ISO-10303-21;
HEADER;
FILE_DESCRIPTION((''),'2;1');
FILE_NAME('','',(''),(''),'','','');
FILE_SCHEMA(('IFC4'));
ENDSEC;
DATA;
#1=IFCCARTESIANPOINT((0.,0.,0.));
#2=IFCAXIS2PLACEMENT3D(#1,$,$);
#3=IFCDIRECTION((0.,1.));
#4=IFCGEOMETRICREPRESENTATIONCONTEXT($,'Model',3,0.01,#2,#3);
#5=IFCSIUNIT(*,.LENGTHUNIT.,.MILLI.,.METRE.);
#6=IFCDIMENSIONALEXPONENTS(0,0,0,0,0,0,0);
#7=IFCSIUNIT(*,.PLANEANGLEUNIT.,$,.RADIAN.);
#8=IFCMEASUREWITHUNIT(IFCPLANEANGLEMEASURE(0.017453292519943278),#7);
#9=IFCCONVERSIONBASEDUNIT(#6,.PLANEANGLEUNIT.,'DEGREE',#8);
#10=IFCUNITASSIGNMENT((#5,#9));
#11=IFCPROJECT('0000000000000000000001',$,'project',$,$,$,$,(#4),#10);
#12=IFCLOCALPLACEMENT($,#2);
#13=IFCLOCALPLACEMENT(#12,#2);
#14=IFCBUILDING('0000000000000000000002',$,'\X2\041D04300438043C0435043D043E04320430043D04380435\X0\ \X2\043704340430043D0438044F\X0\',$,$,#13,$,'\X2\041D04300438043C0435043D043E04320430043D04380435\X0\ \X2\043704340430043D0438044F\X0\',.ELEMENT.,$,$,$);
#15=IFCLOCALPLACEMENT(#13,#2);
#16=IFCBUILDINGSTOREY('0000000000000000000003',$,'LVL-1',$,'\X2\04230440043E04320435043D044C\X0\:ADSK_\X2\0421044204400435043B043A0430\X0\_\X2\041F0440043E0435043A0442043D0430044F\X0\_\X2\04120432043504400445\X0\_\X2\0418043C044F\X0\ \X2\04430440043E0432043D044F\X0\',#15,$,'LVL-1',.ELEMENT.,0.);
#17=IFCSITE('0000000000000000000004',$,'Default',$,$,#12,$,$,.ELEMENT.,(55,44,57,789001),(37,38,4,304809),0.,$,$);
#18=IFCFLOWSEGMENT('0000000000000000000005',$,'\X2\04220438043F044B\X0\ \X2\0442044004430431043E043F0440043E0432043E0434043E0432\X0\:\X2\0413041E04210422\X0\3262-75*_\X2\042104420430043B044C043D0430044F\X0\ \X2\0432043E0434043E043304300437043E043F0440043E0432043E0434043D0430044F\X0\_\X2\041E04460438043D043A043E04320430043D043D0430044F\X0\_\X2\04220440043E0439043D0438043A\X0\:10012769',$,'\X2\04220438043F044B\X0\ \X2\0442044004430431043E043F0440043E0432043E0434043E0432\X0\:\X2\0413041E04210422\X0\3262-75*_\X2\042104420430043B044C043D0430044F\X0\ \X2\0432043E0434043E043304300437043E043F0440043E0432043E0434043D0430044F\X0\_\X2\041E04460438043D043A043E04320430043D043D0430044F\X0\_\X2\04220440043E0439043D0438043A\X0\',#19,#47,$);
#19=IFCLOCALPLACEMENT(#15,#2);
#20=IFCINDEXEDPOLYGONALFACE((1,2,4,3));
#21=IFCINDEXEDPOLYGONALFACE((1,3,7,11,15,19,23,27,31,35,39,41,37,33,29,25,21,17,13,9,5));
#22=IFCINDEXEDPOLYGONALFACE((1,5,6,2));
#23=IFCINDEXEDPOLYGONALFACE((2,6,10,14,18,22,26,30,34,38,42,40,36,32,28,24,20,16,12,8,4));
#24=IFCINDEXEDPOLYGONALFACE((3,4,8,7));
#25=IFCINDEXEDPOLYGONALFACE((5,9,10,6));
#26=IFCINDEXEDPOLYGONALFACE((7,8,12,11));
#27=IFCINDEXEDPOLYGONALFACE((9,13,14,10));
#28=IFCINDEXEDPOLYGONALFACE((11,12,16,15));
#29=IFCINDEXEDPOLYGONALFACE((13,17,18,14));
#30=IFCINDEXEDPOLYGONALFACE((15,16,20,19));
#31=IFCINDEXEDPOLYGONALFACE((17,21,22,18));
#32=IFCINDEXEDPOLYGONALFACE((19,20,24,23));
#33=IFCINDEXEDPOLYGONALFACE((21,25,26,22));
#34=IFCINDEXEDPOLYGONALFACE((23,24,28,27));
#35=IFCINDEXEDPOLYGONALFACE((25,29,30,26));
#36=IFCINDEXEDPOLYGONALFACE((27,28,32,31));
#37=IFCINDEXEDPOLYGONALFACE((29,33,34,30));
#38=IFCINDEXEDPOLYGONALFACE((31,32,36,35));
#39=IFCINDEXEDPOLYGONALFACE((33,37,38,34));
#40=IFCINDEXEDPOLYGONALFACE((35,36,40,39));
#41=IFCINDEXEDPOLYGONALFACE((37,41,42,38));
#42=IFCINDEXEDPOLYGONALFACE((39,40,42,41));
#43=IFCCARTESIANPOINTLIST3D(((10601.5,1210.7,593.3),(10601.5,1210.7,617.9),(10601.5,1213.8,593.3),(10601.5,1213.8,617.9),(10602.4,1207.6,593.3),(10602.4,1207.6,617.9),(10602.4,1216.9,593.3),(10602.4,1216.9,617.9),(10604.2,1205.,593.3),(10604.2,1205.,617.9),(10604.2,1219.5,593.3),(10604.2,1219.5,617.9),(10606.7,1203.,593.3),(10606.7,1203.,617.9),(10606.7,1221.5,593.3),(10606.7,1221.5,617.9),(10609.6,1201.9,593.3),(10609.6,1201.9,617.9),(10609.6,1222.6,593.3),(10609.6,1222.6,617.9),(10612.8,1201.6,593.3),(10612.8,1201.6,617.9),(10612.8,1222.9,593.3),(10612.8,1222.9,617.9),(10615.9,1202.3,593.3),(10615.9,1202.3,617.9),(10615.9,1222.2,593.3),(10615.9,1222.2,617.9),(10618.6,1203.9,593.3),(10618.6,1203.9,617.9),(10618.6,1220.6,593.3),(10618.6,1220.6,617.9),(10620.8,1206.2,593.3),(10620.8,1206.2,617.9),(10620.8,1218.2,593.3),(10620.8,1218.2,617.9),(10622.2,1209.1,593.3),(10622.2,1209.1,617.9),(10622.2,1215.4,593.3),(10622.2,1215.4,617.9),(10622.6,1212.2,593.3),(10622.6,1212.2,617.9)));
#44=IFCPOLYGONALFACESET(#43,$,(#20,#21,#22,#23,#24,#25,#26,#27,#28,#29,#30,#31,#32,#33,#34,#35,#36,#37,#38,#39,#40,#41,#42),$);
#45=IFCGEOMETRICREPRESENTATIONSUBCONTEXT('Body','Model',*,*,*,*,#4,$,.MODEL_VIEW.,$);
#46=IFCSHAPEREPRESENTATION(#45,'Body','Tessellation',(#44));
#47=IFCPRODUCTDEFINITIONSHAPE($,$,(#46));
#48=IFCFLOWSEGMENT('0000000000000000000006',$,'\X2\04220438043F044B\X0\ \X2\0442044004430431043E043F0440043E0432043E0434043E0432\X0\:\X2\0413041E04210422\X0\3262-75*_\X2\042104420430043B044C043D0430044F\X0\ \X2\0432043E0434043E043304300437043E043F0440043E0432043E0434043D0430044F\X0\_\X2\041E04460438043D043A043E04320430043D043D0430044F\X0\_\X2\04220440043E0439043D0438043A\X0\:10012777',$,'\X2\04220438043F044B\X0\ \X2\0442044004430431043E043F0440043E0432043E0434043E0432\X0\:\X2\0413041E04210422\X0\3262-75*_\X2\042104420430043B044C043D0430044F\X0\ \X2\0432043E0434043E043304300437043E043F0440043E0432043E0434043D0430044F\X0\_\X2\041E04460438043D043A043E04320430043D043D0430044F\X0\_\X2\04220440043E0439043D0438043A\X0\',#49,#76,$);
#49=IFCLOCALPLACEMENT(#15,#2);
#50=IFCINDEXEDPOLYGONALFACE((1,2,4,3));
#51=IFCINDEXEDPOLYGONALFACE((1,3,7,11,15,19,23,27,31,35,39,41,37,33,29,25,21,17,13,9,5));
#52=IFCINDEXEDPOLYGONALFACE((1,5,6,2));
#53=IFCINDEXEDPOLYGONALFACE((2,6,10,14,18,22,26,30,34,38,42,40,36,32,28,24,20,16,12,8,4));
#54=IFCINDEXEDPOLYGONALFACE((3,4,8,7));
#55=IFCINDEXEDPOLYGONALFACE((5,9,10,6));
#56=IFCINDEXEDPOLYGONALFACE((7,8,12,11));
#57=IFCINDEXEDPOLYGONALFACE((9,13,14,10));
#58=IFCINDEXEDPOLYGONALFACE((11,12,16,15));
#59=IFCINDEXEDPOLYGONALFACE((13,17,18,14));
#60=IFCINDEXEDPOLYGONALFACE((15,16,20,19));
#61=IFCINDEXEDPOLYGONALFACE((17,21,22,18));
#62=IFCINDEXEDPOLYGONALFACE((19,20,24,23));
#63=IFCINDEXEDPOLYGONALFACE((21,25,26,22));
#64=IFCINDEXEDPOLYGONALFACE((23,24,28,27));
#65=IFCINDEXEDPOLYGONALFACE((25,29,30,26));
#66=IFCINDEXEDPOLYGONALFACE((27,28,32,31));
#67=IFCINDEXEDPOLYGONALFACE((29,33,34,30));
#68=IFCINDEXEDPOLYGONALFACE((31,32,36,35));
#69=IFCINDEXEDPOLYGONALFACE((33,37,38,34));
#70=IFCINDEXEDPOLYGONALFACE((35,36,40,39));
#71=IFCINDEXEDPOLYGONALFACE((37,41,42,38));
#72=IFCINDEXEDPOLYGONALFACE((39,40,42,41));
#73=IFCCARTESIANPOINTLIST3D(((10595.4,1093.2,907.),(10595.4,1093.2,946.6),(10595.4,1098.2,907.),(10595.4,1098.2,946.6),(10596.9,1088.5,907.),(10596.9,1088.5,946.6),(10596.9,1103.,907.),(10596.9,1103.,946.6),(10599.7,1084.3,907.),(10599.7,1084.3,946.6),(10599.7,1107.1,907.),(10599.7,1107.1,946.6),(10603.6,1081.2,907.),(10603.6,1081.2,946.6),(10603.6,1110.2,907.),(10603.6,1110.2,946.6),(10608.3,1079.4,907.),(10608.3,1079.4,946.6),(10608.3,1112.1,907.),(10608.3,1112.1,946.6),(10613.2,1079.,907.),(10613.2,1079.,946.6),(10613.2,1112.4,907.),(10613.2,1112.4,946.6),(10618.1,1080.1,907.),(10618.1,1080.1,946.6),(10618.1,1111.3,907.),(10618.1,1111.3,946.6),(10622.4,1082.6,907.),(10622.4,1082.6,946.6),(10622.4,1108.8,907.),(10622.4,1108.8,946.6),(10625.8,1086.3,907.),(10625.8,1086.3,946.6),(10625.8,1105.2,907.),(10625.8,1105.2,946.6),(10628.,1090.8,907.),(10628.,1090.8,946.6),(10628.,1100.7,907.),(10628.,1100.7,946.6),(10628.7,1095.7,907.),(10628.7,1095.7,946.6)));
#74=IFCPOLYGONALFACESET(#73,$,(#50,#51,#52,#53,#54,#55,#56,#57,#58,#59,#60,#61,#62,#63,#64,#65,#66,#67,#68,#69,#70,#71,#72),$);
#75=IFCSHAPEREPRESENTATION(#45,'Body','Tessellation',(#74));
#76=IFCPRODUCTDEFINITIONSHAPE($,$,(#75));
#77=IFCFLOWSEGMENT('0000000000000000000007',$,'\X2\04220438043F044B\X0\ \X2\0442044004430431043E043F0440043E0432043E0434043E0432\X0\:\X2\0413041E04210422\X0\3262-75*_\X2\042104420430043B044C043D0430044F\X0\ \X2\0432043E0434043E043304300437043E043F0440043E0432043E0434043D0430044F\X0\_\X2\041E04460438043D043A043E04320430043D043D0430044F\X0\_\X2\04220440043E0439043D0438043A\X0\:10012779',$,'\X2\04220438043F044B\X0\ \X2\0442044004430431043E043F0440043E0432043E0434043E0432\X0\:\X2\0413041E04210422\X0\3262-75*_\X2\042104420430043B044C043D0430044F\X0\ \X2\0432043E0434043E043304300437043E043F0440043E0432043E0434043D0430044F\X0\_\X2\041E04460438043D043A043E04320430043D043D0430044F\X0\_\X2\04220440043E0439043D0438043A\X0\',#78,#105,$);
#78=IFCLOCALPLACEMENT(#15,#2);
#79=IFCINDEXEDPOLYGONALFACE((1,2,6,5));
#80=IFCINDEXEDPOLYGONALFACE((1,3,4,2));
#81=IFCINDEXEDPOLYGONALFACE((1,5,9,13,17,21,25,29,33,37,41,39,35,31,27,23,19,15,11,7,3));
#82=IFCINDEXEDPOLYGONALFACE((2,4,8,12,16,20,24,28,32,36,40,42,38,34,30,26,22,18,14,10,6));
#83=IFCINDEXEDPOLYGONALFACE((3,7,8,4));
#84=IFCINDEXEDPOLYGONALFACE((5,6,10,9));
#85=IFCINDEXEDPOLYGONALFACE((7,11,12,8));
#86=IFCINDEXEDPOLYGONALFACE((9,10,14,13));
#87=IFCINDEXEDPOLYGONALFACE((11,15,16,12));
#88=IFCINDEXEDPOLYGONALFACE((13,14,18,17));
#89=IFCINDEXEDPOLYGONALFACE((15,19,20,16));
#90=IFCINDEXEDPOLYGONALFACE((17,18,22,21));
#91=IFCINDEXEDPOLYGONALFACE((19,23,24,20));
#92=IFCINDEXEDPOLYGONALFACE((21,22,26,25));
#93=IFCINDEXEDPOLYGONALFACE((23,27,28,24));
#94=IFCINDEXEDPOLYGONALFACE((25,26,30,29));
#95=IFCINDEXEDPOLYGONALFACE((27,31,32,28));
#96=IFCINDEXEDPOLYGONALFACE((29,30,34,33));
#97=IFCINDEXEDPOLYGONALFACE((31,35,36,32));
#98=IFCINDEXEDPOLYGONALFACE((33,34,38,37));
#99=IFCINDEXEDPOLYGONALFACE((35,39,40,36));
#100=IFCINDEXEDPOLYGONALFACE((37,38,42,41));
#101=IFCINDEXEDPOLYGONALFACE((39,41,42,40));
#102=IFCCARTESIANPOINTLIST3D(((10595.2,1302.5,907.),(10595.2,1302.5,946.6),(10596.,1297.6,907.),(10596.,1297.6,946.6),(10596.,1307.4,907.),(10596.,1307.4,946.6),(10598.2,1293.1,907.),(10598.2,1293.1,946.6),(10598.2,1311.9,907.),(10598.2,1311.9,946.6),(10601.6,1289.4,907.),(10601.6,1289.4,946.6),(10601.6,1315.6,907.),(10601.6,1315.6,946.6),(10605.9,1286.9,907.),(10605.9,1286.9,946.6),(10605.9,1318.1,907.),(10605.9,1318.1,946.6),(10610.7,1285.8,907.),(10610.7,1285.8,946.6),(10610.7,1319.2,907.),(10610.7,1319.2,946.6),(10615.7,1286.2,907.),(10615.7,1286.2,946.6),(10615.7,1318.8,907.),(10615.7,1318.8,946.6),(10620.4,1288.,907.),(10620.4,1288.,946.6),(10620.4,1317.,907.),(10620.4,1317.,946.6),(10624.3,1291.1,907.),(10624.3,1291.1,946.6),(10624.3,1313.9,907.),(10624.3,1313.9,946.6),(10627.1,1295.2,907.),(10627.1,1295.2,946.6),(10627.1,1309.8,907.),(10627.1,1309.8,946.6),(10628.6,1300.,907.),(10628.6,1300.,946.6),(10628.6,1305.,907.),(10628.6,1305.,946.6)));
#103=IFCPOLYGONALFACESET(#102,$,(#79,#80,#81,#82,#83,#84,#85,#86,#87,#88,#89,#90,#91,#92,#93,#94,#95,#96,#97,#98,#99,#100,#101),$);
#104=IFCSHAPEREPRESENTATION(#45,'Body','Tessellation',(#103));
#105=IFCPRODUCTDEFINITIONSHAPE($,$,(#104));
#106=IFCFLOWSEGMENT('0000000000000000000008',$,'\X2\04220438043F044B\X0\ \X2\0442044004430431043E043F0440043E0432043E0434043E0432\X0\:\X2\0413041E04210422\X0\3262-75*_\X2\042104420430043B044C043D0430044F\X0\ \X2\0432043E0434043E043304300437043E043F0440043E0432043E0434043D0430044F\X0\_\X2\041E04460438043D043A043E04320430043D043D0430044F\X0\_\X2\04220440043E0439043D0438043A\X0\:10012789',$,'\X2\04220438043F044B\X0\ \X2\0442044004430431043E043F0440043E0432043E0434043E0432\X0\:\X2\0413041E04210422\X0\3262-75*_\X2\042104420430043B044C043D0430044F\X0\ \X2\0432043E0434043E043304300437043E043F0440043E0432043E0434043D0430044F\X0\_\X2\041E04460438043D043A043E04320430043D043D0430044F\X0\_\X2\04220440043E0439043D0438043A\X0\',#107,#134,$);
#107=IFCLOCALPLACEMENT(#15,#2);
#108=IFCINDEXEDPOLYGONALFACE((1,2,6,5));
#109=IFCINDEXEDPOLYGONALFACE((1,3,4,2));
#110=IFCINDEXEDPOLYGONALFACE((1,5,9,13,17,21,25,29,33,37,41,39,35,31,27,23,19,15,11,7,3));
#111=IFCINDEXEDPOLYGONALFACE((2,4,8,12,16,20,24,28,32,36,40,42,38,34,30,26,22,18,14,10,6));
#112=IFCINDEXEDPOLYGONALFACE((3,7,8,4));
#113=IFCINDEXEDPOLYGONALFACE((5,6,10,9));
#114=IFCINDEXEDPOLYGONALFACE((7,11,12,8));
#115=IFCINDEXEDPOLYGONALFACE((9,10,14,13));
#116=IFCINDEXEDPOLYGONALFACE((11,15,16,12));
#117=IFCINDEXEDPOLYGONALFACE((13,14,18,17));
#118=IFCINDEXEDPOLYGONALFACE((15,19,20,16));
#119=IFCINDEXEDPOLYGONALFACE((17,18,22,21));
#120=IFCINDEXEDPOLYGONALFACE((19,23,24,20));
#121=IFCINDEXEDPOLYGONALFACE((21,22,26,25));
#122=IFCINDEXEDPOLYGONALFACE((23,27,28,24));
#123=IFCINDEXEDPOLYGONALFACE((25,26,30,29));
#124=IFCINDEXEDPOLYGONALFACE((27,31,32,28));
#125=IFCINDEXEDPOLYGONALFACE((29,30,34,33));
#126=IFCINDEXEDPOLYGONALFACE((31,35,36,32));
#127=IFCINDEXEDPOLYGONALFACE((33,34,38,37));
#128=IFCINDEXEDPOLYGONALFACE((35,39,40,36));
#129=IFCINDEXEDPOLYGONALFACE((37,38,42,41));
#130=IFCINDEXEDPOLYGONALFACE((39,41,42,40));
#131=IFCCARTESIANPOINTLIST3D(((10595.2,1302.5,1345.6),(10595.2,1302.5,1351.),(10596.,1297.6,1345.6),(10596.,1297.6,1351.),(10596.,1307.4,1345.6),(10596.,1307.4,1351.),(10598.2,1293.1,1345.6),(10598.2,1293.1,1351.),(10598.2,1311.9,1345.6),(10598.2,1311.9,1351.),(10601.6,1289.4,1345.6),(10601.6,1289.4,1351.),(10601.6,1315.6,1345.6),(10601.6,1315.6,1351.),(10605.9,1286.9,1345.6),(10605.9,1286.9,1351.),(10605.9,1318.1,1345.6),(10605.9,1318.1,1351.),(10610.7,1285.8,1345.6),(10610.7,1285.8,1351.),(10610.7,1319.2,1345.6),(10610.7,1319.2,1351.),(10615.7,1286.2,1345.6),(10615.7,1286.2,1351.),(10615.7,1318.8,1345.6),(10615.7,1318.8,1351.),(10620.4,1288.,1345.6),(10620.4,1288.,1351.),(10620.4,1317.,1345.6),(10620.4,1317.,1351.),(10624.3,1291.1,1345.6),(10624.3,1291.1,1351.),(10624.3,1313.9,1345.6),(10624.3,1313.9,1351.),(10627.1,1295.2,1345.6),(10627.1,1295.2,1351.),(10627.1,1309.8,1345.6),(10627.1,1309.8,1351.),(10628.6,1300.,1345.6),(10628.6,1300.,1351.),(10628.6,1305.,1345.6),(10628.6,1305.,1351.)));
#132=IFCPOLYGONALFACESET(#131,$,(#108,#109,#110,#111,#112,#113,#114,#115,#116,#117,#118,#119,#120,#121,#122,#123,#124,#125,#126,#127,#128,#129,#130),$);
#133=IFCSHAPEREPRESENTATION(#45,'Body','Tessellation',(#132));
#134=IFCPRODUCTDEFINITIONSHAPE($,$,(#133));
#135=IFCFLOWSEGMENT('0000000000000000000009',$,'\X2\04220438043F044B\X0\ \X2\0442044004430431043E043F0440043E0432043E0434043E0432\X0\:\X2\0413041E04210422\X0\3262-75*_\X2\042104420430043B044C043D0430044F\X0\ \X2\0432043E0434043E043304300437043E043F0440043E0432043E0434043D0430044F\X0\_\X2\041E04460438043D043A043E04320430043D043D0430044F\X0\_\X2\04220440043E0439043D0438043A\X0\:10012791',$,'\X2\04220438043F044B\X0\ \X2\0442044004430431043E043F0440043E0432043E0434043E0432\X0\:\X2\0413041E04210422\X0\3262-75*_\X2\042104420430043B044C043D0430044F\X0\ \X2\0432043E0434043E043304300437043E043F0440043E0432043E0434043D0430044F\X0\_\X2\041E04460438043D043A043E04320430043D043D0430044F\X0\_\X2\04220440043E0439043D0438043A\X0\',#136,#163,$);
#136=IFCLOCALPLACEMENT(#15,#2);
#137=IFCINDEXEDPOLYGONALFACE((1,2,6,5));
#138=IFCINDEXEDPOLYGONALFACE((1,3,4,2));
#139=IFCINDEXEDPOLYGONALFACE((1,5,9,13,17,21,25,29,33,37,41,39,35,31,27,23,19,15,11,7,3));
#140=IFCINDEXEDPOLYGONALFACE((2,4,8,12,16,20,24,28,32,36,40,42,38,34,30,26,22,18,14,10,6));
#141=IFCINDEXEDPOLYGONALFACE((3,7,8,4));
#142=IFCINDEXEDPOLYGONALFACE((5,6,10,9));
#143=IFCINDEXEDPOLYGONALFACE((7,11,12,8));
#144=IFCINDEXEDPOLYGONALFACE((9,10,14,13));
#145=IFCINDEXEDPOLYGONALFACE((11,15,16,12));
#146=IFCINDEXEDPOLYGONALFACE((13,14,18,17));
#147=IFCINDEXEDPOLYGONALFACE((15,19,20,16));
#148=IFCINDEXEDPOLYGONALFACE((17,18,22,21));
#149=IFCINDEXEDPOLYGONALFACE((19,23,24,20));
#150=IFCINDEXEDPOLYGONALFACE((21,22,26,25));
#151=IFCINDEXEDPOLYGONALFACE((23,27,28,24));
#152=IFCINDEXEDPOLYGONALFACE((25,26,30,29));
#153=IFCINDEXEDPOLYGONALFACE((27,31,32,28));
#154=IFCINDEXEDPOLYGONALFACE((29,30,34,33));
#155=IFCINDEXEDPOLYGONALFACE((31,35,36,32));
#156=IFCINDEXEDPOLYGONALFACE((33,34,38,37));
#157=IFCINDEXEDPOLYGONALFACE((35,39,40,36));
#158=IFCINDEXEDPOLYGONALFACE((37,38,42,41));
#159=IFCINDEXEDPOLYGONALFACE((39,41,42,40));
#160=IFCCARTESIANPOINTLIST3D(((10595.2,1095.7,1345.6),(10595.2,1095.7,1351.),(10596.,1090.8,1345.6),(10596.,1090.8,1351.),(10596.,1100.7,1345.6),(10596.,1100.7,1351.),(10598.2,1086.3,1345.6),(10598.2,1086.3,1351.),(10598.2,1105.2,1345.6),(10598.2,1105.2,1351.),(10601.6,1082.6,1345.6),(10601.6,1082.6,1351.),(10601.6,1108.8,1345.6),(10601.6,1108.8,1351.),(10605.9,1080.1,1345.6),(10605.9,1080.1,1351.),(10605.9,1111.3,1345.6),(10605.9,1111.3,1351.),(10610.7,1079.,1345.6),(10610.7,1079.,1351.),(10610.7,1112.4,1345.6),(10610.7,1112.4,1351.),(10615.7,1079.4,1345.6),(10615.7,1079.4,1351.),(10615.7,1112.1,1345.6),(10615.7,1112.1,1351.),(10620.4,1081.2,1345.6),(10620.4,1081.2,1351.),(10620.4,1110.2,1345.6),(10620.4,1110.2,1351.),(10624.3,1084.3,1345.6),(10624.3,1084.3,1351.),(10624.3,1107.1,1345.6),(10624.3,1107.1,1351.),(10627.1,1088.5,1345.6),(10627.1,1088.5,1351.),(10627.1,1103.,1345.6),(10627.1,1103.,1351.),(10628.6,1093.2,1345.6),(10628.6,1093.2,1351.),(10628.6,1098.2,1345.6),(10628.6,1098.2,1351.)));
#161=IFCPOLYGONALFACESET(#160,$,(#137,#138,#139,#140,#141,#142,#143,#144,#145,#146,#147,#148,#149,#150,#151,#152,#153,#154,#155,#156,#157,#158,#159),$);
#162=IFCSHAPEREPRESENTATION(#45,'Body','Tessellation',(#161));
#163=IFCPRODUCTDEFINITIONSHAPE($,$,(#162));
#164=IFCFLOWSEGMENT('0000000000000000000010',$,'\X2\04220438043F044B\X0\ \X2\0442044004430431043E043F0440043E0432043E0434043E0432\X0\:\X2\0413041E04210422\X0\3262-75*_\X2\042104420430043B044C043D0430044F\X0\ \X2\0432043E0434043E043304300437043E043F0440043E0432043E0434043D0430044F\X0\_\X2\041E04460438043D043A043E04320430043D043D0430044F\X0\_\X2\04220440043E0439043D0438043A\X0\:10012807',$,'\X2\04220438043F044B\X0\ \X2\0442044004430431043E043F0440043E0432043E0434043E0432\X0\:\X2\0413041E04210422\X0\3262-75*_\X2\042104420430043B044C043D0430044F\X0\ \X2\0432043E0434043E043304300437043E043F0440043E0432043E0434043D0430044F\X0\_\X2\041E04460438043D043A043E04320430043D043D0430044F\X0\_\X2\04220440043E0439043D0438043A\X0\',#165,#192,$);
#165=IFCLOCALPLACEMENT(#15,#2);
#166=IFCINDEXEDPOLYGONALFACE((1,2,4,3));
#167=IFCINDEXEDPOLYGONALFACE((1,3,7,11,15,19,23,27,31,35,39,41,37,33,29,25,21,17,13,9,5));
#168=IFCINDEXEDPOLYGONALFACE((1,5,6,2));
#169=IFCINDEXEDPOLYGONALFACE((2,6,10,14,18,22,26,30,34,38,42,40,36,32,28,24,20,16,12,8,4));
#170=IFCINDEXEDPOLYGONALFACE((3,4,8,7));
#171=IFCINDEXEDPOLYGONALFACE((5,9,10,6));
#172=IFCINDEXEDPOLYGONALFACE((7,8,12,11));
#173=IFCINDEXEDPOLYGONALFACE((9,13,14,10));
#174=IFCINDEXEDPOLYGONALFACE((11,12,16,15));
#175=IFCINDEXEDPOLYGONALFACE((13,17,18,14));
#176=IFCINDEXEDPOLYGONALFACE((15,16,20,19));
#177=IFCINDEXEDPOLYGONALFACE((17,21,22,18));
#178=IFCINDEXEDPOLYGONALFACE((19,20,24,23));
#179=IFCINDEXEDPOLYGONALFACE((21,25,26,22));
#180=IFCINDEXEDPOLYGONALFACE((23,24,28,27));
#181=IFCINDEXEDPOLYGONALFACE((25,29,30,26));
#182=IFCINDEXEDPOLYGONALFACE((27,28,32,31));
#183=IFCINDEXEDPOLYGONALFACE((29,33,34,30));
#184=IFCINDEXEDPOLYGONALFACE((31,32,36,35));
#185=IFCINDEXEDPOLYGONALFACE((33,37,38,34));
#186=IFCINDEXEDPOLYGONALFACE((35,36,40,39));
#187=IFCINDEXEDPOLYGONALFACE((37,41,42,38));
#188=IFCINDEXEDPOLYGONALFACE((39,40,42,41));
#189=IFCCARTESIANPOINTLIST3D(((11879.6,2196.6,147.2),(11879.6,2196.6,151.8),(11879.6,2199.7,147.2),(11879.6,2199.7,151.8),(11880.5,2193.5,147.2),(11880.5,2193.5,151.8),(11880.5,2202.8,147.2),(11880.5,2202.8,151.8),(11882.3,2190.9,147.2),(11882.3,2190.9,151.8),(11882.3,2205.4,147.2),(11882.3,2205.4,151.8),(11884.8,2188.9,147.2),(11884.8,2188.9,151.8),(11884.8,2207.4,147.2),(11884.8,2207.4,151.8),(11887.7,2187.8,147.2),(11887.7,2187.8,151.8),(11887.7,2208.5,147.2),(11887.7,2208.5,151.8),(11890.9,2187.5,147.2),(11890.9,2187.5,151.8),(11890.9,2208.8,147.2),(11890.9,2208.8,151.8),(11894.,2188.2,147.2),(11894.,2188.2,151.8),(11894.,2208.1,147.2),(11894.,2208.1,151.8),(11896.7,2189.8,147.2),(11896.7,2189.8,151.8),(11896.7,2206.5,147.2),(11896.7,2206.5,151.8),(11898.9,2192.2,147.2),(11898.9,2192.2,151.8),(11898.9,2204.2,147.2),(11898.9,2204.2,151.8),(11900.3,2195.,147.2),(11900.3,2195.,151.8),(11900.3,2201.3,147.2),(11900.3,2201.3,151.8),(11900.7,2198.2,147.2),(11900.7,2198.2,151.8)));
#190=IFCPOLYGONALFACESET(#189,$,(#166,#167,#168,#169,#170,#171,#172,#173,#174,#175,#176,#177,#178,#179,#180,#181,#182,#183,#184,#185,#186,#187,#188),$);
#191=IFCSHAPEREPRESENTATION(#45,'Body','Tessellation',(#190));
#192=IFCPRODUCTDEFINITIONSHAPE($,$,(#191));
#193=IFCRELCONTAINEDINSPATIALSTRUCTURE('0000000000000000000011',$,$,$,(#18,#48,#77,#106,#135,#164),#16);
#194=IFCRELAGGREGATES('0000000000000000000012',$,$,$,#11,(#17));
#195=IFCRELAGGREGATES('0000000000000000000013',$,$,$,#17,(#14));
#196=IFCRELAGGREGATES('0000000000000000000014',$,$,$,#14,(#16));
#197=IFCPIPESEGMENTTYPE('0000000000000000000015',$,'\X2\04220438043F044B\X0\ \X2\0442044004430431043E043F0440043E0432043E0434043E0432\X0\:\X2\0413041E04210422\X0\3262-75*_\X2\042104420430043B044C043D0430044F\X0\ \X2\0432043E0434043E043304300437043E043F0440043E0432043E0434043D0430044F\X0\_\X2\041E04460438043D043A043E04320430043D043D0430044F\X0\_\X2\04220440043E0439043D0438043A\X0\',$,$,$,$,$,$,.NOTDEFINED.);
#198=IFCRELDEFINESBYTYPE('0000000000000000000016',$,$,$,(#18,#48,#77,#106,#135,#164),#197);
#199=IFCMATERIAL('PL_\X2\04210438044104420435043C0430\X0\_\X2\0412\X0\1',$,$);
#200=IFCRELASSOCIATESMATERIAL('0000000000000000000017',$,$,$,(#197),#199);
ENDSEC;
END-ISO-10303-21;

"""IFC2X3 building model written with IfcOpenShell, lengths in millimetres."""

from ifc_helpers import new_model, entity, si_unit, converted_unit, direction, frame, frame_2d, origin, origin_2d_with_axis, place, context, subcontext, project, spatial, circle, extrude, material, type_object, element, save


model = new_model("IFC2X3")

# Units and contexts
model_context = context("Model", 3, precision=0.01, world=origin(), true_north=direction((0.0, 1.0)))
body_context = subcontext(model_context, "Body", "Model", "MODEL_VIEW")
ifc_project = project(units=[si_unit("LENGTHUNIT", "METRE", prefix="MILLI"), converted_unit("PLANEANGLEUNIT", "DEGREE", entity("IfcPlaneAngleMeasure", 0.017453292519943278), si_unit("PLANEANGLEUNIT", "RADIAN"), dimensions=[0, 0, 0, 0, 0, 0, 0])], contexts=[model_context])

# Site, building, storey
site_placement = place(None, origin())
site = spatial("IfcSite", under=ifc_project, at=site_placement, Name="Default", CompositionType="ELEMENT", RefLatitude=(55, 44, 57, 789001), RefLongitude=(37, 38, 4, 304809), RefElevation=0.0)
building_placement = place(site_placement, origin())
building = spatial("IfcBuilding", under=site, at=building_placement, Name="Наименование здания", LongName="Наименование здания", CompositionType="ELEMENT")
storey_placement = place(building_placement, origin())
storey = spatial("IfcBuildingStorey", under=building, at=storey_placement, Name="LVL-1", ObjectType="Уровень:ADSK_Стрелка_Проектная_Вверх_Имя уровня", LongName="LVL-1", CompositionType="ELEMENT", Elevation=0.0)

# Flow segments
ifc_material_1 = material(Name="PL_Система_В1")
pipe_segment_type_1 = type_object("IfcPipeSegmentType", Name="Типы трубопроводов:ГОСТ3262-75*_Стальная водогазопроводная_Оцинкованная_Тройник", PredefinedType="NOTDEFINED", material=ifc_material_1)
flow_segment_1_placement = place(storey_placement, origin())
element("IfcFlowSegment", 1, at=flow_segment_1_placement, inside=storey, type_object=pipe_segment_type_1, Name="Типы трубопроводов:ГОСТ3262-75*_Стальная водогазопроводная_Оцинкованная_Тройник:10012769", ObjectType="Типы трубопроводов:ГОСТ3262-75*_Стальная водогазопроводная_Оцинкованная_Тройник", context=body_context, shape_type="SweptSolid", body=[
    extrude(circle(Radius=10.7, at=origin_2d_with_axis()), frame((10612.0, 1212.2, 593.3)), (0.0, 0.0, 1.0), 24.6),
])
flow_segment_2_placement = place(storey_placement, origin())
element("IfcFlowSegment", 2, at=flow_segment_2_placement, inside=storey, type_object=pipe_segment_type_1, Name="Типы трубопроводов:ГОСТ3262-75*_Стальная водогазопроводная_Оцинкованная_Тройник:10012777", ObjectType="Типы трубопроводов:ГОСТ3262-75*_Стальная водогазопроводная_Оцинкованная_Тройник", context=body_context, shape_type="SweptSolid", body=[
    extrude(circle(Radius=16.8, at=origin_2d_with_axis()), frame((10612.0, 1095.7, 907.0)), (0.0, 0.0, 1.0), 39.6),
])
flow_segment_3_placement = place(storey_placement, origin())
element("IfcFlowSegment", 3, at=flow_segment_3_placement, inside=storey, type_object=pipe_segment_type_1, Name="Типы трубопроводов:ГОСТ3262-75*_Стальная водогазопроводная_Оцинкованная_Тройник:10012779", ObjectType="Типы трубопроводов:ГОСТ3262-75*_Стальная водогазопроводная_Оцинкованная_Тройник", context=body_context, shape_type="SweptSolid", body=[
    extrude(circle(Radius=16.8, at=origin_2d_with_axis()), frame((10612.0, 1302.5, 907.0), z_axis=(0.0, 0.0, 1.0), x_axis=(-1.0, 0.0, 0.0)), (0.0, 0.0, 1.0), 39.6),
])
flow_segment_4_placement = place(storey_placement, origin())
element("IfcFlowSegment", 4, at=flow_segment_4_placement, inside=storey, type_object=pipe_segment_type_1, Name="Типы трубопроводов:ГОСТ3262-75*_Стальная водогазопроводная_Оцинкованная_Тройник:10012789", ObjectType="Типы трубопроводов:ГОСТ3262-75*_Стальная водогазопроводная_Оцинкованная_Тройник", context=body_context, shape_type="SweptSolid", body=[
    extrude(circle(Radius=16.8, at=origin_2d_with_axis()), frame((10612.0, 1302.5, 1345.6), z_axis=(0.0, 0.0, 1.0), x_axis=(-1.0, 0.0, 0.0)), (0.0, 0.0, 1.0), 5.4),
])
flow_segment_5_placement = place(storey_placement, origin())
element("IfcFlowSegment", 5, at=flow_segment_5_placement, inside=storey, type_object=pipe_segment_type_1, Name="Типы трубопроводов:ГОСТ3262-75*_Стальная водогазопроводная_Оцинкованная_Тройник:10012791", ObjectType="Типы трубопроводов:ГОСТ3262-75*_Стальная водогазопроводная_Оцинкованная_Тройник", context=body_context, shape_type="SweptSolid", body=[
    extrude(circle(Radius=16.8, at=origin_2d_with_axis()), frame((10612.0, 1095.7, 1345.6), z_axis=(0.0, 0.0, 1.0), x_axis=(-1.0, 0.0, 0.0)), (0.0, 0.0, 1.0), 5.4),
])
flow_segment_6_placement = place(storey_placement, origin())
element("IfcFlowSegment", 6, at=flow_segment_6_placement, inside=storey, type_object=pipe_segment_type_1, Name="Типы трубопроводов:ГОСТ3262-75*_Стальная водогазопроводная_Оцинкованная_Тройник:10012807", ObjectType="Типы трубопроводов:ГОСТ3262-75*_Стальная водогазопроводная_Оцинкованная_Тройник", context=body_context, shape_type="SweptSolid", body=[
    extrude(circle(Radius=10.7, at=frame_2d((0.0, 0.0), x_axis=(1.0, 0.0))), frame((11890.1, 2198.2, 147.2)), (0.0, 0.0, 1.0), 4.5),
])

save(model, "model.ifc")
